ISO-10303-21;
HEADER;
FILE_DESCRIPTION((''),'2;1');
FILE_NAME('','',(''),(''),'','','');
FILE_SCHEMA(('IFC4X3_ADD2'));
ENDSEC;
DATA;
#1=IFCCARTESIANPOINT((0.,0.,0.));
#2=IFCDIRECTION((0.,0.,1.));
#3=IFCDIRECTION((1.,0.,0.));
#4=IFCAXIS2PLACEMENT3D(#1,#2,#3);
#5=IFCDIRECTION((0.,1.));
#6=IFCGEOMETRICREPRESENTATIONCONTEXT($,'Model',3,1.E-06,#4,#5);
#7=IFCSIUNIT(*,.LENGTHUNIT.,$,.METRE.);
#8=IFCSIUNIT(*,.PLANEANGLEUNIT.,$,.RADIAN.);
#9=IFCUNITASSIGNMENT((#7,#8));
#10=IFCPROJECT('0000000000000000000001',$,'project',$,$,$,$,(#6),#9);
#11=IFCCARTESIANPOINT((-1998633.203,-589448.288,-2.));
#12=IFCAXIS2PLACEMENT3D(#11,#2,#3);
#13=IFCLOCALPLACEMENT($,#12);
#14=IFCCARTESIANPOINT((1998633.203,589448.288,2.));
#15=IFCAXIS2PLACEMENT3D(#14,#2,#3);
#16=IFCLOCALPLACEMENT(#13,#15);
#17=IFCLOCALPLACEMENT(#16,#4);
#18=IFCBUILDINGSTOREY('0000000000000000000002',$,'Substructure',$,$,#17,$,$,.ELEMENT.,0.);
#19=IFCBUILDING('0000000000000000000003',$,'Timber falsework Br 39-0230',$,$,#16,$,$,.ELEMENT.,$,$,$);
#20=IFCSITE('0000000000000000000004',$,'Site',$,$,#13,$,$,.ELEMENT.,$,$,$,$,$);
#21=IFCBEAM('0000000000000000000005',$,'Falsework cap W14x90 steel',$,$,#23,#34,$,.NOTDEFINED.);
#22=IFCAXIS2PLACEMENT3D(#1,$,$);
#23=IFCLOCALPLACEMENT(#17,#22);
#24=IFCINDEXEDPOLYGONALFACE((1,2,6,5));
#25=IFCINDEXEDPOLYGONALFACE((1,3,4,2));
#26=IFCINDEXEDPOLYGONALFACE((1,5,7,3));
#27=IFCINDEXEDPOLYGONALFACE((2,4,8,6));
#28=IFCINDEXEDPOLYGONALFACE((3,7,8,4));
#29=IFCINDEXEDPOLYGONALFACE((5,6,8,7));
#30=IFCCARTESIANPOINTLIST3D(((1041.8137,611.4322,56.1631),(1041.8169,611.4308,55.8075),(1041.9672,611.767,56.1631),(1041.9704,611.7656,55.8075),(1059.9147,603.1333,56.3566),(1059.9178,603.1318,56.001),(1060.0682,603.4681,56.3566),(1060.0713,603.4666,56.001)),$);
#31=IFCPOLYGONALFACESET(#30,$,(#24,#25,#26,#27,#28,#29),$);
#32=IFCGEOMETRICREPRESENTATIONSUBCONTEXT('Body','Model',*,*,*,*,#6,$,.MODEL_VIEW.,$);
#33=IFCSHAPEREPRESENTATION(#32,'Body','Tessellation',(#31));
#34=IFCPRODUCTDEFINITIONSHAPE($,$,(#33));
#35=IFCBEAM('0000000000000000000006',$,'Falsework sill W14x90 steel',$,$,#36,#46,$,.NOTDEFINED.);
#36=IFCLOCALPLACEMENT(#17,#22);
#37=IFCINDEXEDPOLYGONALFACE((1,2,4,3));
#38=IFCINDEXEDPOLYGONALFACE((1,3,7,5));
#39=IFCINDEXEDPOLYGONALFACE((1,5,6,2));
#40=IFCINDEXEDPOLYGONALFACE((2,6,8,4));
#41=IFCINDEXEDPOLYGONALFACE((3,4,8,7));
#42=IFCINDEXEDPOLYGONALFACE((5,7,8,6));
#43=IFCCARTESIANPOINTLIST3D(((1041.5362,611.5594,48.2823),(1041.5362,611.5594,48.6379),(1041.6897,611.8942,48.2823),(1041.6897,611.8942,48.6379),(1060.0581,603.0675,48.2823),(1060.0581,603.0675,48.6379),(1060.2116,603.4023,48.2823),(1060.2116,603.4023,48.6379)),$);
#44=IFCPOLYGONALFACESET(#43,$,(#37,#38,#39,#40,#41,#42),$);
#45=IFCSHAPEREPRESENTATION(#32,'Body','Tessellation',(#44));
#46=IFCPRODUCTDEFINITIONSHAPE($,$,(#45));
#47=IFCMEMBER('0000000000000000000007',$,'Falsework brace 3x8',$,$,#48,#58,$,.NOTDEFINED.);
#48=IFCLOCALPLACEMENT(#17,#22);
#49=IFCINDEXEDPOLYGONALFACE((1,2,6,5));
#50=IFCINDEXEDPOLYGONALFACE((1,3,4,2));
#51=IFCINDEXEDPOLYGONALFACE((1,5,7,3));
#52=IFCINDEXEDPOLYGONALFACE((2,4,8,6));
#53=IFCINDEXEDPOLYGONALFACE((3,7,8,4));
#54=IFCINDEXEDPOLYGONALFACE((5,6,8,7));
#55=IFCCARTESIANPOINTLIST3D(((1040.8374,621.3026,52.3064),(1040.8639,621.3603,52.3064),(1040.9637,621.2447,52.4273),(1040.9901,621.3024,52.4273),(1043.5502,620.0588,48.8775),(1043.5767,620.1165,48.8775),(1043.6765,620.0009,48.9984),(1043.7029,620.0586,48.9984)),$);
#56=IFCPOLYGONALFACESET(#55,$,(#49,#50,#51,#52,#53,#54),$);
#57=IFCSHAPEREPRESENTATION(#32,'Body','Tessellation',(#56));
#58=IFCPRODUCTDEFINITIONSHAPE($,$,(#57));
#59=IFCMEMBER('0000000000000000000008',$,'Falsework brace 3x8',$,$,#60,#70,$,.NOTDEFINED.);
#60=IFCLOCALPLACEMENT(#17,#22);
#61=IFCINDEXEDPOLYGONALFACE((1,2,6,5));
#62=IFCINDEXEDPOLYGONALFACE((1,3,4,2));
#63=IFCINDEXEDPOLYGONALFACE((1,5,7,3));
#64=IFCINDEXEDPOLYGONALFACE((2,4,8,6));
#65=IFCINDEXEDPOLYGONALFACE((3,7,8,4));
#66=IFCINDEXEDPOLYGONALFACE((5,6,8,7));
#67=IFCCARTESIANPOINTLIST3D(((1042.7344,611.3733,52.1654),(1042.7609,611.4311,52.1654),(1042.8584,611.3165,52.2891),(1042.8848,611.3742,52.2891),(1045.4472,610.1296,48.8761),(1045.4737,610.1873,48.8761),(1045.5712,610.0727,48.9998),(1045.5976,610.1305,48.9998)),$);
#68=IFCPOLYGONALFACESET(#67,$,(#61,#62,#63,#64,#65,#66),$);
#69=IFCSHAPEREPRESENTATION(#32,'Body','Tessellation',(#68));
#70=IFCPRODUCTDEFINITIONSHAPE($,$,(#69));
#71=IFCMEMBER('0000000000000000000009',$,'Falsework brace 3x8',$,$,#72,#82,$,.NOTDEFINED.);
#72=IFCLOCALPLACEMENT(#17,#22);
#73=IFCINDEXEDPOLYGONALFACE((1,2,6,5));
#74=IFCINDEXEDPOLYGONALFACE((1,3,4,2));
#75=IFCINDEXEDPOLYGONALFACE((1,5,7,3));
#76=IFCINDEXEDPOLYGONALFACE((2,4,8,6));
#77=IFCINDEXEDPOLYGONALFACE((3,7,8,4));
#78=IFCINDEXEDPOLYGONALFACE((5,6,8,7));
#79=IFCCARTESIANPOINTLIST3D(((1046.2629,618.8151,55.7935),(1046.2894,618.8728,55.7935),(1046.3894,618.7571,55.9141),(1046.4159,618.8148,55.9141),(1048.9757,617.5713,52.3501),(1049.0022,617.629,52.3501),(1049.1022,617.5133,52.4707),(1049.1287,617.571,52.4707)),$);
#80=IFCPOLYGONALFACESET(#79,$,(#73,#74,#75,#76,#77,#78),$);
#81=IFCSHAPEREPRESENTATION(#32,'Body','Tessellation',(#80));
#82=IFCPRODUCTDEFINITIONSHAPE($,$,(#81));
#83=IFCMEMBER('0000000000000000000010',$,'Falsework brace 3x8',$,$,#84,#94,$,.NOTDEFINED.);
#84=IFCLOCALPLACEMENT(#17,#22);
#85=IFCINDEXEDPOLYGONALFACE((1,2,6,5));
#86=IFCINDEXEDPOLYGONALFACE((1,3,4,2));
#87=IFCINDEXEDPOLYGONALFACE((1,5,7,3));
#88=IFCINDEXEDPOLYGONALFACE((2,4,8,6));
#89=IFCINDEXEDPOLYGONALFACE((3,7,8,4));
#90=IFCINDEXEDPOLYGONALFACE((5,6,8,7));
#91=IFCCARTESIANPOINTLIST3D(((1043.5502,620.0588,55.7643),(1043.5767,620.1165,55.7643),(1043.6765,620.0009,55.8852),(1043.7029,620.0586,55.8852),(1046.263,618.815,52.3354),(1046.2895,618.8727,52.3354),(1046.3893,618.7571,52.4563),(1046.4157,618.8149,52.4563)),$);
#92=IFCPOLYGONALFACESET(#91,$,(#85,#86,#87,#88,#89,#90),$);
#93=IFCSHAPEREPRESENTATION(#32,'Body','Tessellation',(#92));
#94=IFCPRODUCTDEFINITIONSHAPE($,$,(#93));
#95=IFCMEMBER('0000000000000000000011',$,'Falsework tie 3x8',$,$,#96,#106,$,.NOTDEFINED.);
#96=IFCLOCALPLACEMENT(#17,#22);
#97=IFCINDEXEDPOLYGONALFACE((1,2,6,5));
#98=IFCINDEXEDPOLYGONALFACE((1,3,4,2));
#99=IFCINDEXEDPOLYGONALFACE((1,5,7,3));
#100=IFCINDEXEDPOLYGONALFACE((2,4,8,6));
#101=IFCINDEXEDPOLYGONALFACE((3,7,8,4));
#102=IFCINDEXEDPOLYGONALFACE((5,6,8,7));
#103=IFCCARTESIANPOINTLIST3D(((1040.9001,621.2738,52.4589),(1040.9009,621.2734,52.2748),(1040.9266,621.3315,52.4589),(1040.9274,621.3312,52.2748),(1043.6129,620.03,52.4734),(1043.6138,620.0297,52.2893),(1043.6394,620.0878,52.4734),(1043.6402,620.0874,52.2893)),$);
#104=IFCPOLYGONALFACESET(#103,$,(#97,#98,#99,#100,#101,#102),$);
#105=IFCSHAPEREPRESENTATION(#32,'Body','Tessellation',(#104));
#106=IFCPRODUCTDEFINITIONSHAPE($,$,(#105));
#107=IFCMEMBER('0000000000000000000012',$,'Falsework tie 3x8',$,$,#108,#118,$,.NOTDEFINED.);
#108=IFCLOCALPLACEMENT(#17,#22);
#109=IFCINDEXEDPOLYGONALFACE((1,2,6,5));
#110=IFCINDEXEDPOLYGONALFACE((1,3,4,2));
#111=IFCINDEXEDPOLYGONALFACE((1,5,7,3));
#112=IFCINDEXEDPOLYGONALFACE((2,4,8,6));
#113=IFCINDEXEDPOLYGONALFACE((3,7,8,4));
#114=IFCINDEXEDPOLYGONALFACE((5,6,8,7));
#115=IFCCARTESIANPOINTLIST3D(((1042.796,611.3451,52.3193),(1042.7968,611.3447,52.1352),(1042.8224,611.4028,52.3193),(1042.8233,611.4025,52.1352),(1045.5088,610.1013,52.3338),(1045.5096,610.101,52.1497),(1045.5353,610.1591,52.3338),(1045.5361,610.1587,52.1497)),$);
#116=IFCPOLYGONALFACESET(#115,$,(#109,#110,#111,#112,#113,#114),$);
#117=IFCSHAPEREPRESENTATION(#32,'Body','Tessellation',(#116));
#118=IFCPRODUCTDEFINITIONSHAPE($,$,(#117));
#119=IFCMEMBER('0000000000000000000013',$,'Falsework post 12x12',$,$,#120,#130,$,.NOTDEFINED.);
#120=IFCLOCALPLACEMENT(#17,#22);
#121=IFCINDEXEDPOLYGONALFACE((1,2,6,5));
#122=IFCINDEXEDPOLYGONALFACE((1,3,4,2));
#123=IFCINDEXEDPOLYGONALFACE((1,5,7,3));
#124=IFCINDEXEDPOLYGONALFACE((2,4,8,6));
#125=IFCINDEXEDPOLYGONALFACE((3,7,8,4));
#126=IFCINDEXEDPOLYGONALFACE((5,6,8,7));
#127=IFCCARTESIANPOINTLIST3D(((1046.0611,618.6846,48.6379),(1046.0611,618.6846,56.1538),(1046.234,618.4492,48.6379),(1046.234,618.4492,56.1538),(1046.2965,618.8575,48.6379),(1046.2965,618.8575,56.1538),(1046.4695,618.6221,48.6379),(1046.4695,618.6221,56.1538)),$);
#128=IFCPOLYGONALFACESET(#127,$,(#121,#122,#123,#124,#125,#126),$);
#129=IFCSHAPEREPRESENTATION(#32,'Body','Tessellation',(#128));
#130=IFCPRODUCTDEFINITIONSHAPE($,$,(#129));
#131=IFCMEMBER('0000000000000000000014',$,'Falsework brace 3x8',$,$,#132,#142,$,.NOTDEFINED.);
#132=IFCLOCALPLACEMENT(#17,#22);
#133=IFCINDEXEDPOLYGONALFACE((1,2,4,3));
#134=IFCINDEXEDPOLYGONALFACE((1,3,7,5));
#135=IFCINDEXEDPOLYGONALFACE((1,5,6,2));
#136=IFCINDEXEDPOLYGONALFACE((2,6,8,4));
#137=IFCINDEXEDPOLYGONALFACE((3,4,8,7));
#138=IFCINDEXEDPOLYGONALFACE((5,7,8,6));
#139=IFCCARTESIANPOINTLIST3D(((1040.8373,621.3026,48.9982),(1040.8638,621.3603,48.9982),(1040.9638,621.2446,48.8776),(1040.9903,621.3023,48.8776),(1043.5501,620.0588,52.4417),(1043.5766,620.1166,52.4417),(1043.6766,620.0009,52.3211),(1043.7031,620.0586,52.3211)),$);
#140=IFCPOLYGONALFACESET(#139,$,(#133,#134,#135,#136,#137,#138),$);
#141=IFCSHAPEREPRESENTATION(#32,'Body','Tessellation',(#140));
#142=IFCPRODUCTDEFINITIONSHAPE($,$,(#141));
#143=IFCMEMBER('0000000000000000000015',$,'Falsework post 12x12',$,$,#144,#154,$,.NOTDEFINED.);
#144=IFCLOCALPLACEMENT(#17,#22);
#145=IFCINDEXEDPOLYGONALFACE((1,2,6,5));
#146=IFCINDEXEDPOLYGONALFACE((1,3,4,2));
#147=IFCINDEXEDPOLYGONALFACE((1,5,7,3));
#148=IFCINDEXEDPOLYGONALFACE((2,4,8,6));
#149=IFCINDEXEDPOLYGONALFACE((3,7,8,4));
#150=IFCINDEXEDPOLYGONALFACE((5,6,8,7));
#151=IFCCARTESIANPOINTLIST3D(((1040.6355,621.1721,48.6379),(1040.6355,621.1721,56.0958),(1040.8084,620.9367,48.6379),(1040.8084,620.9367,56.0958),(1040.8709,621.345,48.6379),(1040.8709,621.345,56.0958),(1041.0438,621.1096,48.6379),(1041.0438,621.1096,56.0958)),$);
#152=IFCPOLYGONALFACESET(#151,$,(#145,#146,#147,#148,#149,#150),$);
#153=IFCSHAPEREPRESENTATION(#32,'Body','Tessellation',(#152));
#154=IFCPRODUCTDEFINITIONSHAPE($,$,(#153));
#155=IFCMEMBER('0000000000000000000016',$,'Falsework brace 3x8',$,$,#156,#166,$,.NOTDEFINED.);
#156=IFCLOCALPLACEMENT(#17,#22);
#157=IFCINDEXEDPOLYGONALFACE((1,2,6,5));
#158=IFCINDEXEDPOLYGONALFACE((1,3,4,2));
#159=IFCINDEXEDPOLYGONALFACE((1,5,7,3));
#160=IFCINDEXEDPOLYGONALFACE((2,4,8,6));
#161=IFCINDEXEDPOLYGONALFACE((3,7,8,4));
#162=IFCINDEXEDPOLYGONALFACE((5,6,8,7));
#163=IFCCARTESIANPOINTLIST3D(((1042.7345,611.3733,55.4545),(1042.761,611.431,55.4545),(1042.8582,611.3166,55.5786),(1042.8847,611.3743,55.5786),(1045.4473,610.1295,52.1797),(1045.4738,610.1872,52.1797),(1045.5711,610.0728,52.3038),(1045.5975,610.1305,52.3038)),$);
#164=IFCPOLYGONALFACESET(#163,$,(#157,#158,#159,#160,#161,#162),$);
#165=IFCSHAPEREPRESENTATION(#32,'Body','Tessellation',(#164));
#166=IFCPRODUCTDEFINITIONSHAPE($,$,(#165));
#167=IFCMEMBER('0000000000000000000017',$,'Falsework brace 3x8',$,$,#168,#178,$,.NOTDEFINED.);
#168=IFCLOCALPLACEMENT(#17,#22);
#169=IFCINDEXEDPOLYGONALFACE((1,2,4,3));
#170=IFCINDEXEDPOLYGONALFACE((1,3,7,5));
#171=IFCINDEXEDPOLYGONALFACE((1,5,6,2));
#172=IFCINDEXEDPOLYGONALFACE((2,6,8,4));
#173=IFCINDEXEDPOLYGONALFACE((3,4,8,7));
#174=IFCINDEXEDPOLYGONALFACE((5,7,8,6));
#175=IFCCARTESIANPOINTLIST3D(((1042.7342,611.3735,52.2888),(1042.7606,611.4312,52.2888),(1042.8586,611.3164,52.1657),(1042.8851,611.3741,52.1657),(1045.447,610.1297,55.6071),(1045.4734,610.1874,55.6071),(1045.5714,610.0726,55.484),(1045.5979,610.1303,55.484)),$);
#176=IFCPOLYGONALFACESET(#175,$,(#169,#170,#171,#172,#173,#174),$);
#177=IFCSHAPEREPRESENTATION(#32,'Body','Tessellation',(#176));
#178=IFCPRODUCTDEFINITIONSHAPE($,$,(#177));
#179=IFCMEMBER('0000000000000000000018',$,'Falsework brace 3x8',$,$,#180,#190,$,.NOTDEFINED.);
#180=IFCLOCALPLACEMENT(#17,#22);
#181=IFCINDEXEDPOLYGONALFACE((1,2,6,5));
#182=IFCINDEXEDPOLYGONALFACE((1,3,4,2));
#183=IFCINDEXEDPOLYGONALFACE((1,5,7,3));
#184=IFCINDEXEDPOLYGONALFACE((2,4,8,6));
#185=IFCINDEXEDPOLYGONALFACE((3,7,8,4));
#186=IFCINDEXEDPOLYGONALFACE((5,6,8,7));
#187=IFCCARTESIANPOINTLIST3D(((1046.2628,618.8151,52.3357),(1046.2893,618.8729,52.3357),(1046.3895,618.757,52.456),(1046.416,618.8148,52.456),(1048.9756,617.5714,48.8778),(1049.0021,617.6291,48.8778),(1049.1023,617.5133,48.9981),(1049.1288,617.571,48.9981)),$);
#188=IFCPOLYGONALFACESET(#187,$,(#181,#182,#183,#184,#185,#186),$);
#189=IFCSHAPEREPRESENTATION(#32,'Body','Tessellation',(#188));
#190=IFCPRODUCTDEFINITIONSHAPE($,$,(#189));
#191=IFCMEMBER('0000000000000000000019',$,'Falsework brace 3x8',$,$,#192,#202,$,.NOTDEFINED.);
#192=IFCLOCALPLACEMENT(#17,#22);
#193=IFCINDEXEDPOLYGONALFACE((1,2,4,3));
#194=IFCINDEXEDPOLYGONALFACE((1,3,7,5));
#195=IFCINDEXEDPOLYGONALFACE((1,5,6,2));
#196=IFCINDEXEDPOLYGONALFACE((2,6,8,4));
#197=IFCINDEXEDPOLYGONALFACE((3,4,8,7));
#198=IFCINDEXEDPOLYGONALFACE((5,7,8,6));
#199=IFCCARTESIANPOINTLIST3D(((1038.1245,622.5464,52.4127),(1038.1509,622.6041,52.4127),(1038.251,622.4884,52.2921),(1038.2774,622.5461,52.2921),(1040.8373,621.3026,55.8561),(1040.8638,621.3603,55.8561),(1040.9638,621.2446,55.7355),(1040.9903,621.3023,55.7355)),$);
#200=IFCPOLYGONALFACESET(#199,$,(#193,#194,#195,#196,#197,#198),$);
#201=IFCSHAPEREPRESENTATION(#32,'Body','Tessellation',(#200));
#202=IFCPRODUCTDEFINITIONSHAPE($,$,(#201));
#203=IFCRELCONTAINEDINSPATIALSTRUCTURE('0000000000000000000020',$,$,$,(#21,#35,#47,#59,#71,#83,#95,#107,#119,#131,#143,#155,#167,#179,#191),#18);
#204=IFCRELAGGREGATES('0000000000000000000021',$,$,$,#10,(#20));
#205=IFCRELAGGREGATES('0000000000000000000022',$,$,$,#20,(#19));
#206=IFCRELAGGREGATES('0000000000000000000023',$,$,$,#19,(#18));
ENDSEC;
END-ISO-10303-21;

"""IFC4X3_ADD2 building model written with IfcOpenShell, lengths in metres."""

from ifc_helpers import new_model, si_unit, direction, frame, frame_2d, origin, origin_with_axes, origin_2d, place, context, subcontext, project, spatial, rectangle, extrude, element, save


model = new_model("IFC4X3_ADD2")

# Units and contexts
model_context = context("Model", 3, precision=1e-06, world=origin_with_axes(), true_north=direction((0.0, 1.0)))
body_context = subcontext(model_context, "Body", "Model", "MODEL_VIEW")
ifc_project = project(units=[si_unit("LENGTHUNIT", "METRE"), si_unit("PLANEANGLEUNIT", "RADIAN")], contexts=[model_context])

# Site, building, storey
site_placement = place(None, frame((-1998633.203, -589448.288, -2.0), z_axis=(0.0, 0.0, 1.0), x_axis=(1.0, 0.0, 0.0)))
site = spatial("IfcSite", under=ifc_project, at=site_placement, Name="Site", CompositionType="ELEMENT")
building_placement = place(site_placement, frame((1998633.203, 589448.288, 2.0), z_axis=(0.0, 0.0, 1.0), x_axis=(1.0, 0.0, 0.0)))
building = spatial("IfcBuilding", under=site, at=building_placement, Name="Timber falsework Br 39-0230", CompositionType="ELEMENT")
storey_placement = place(building_placement, origin_with_axes())
storey = spatial("IfcBuildingStorey", under=building, at=storey_placement, Name="Substructure", CompositionType="ELEMENT", Elevation=0.0)

# Beams
beam_1_placement = place(storey_placement, frame((1041.8936, 611.5982, 55.8075), z_axis=(0.908971, -0.416746, 0.009717), x_axis=(0.416765, 0.909014, 0.0)))
element("IfcBeam", 1, at=beam_1_placement, inside=storey, Name="Falsework cap W14x90 steel", PredefinedType="NOTDEFINED", context=body_context, shape_type="SweptSolid", body=[
    extrude(rectangle(XDim=0.3683, YDim=0.3556, at=frame_2d((0.0, 0.1778))), origin(), (0.0, 0.0, 1.0), 19.9137),
])
beam_2_placement = place(storey_placement, frame((1041.613, 611.7268, 48.2823), z_axis=(0.909014, -0.416765, 0.0), x_axis=(0.416765, 0.909014, 0.0)))
element("IfcBeam", 2, at=beam_2_placement, inside=storey, Name="Falsework sill W14x90 steel", PredefinedType="NOTDEFINED", context=body_context, shape_type="SweptSolid", body=[
    extrude(rectangle(XDim=0.3683, YDim=0.3556, at=frame_2d((0.0, 0.1778))), origin(), (0.0, 0.0, 1.0), 20.3758),
])

# Members
member_1_placement = place(storey_placement, frame((1040.9138, 621.3025, 52.3669), z_axis=(0.59678, -0.273612, -0.754314), x_axis=(0.416765, 0.909014, 0.0)))
element("IfcMember", 3, at=member_1_placement, inside=storey, Name="Falsework brace 3x8", PredefinedType="NOTDEFINED", context=body_context, shape_type="SweptSolid", body=[
    extrude(rectangle(XDim=0.0635, YDim=0.1841, at=origin_2d()), origin(), (0.0, 0.0, 1.0), 4.5457),
])
member_2_placement = place(storey_placement, frame((1042.8096, 611.3738, 52.2272), z_axis=(0.610804, -0.280042, -0.740605), x_axis=(0.416765, 0.909014, 0.0)))
element("IfcMember", 4, at=member_2_placement, inside=storey, Name="Falsework brace 3x8", PredefinedType="NOTDEFINED", context=body_context, shape_type="SweptSolid", body=[
    extrude(rectangle(XDim=0.0635, YDim=0.1841, at=origin_2d()), origin(), (0.0, 0.0, 1.0), 4.4414),
])
member_3_placement = place(storey_placement, frame((1046.3394, 618.8149, 55.8538), z_axis=(0.595346, -0.272955, -0.755684), x_axis=(0.416765, 0.909014, 0.0)))
element("IfcMember", 5, at=member_3_placement, inside=storey, Name="Falsework brace 3x8", PredefinedType="NOTDEFINED", context=body_context, shape_type="SweptSolid", body=[
    extrude(rectangle(XDim=0.0635, YDim=0.1841, at=origin_2d()), origin(), (0.0, 0.0, 1.0), 4.5567),
])
member_4_placement = place(storey_placement, frame((1043.6266, 620.0587, 55.8248), z_axis=(0.59678, -0.273612, -0.754314), x_axis=(0.416765, 0.909014, 0.0)))
element("IfcMember", 6, at=member_4_placement, inside=storey, Name="Falsework brace 3x8", PredefinedType="NOTDEFINED", context=body_context, shape_type="SweptSolid", body=[
    extrude(rectangle(XDim=0.0635, YDim=0.1841, at=origin_2d()), origin(), (0.0, 0.0, 1.0), 4.5457),
])
for number, where, z_axis, x_axis, name in (
    (7, (1040.9138, 621.3025, 52.3669), (0.909003, -0.41676, 0.004859), (0.416765, 0.909014, 0.0), "Falsework tie 3x8"),
    (8, (1042.8096, 611.3738, 52.2272), (0.909003, -0.41676, 0.004859), (0.416765, 0.909014, 0.0), "Falsework tie 3x8"),
):
    element("IfcMember", number, at=place(storey_placement, frame(where, z_axis=z_axis, x_axis=x_axis)), inside=storey, Name=name, PredefinedType="NOTDEFINED", context=body_context, shape_type="SweptSolid", body=[
        extrude(rectangle(XDim=0.0635, YDim=0.1841, at=origin_2d()), origin(), (0.0, 0.0, 1.0), 2.9844),
    ])
member_5_placement = place(storey_placement, frame((1046.2653, 618.6533, 48.6379), z_axis=(0.0, 0.0, 1.0), x_axis=(-0.805928, -0.592013, 0.0)))
element("IfcMember", 9, at=member_5_placement, inside=storey, Name="Falsework post 12x12", PredefinedType="NOTDEFINED", context=body_context, shape_type="SweptSolid", body=[
    extrude(rectangle(XDim=0.2921, YDim=0.2921, at=origin_2d()), origin(), (0.0, 0.0, 1.0), 7.5158),
])
member_6_placement = place(storey_placement, frame((1040.9138, 621.3025, 48.9379), z_axis=(0.595346, -0.272955, 0.755684), x_axis=(0.416765, 0.909014, 0.0)))
element("IfcMember", 10, at=member_6_placement, inside=storey, Name="Falsework brace 3x8", PredefinedType="NOTDEFINED", context=body_context, shape_type="SweptSolid", body=[
    extrude(rectangle(XDim=0.0635, YDim=0.1841, at=origin_2d()), origin(), (0.0, 0.0, 1.0), 4.5567),
])
member_7_placement = place(storey_placement, frame((1040.8397, 621.1409, 48.6379), z_axis=(0.0, 0.0, 1.0), x_axis=(-0.805928, -0.592013, 0.0)))
element("IfcMember", 11, at=member_7_placement, inside=storey, Name="Falsework post 12x12", PredefinedType="NOTDEFINED", context=body_context, shape_type="SweptSolid", body=[
    extrude(rectangle(XDim=0.2921, YDim=0.2921, at=origin_2d()), origin(), (0.0, 0.0, 1.0), 7.4578),
])
member_8_placement = place(storey_placement, frame((1042.8096, 611.3738, 55.5165), z_axis=(0.612283, -0.28072, -0.739125), x_axis=(0.416765, 0.909014, 0.0)))
element("IfcMember", 12, at=member_8_placement, inside=storey, Name="Falsework brace 3x8", PredefinedType="NOTDEFINED", context=body_context, shape_type="SweptSolid", body=[
    extrude(rectangle(XDim=0.0635, YDim=0.1841, at=origin_2d()), origin(), (0.0, 0.0, 1.0), 4.4306),
])
member_9_placement = place(storey_placement, frame((1042.8096, 611.3738, 52.2272), z_axis=(0.607859, -0.278691, 0.743532), x_axis=(0.416765, 0.909014, 0.0)))
element("IfcMember", 13, at=member_9_placement, inside=storey, Name="Falsework brace 3x8", PredefinedType="NOTDEFINED", context=body_context, shape_type="SweptSolid", body=[
    extrude(rectangle(XDim=0.0635, YDim=0.1841, at=origin_2d()), origin(), (0.0, 0.0, 1.0), 4.4629),
])
member_10_placement = place(storey_placement, frame((1046.3394, 618.8149, 52.3959), z_axis=(0.593917, -0.272299, -0.757044), x_axis=(0.416765, 0.909014, 0.0)))
element("IfcMember", 14, at=member_10_placement, inside=storey, Name="Falsework brace 3x8", PredefinedType="NOTDEFINED", context=body_context, shape_type="SweptSolid", body=[
    extrude(rectangle(XDim=0.0635, YDim=0.1841, at=origin_2d()), origin(), (0.0, 0.0, 1.0), 4.5677),
])
member_11_placement = place(storey_placement, frame((1038.201, 622.5462, 52.3524), z_axis=(0.595346, -0.272955, 0.755684), x_axis=(0.416765, 0.909014, 0.0)))
element("IfcMember", 15, at=member_11_placement, inside=storey, Name="Falsework brace 3x8", PredefinedType="NOTDEFINED", context=body_context, shape_type="SweptSolid", body=[
    extrude(rectangle(XDim=0.0635, YDim=0.1841, at=origin_2d()), origin(), (0.0, 0.0, 1.0), 4.5567),
])

save(model, "model.ifc")
